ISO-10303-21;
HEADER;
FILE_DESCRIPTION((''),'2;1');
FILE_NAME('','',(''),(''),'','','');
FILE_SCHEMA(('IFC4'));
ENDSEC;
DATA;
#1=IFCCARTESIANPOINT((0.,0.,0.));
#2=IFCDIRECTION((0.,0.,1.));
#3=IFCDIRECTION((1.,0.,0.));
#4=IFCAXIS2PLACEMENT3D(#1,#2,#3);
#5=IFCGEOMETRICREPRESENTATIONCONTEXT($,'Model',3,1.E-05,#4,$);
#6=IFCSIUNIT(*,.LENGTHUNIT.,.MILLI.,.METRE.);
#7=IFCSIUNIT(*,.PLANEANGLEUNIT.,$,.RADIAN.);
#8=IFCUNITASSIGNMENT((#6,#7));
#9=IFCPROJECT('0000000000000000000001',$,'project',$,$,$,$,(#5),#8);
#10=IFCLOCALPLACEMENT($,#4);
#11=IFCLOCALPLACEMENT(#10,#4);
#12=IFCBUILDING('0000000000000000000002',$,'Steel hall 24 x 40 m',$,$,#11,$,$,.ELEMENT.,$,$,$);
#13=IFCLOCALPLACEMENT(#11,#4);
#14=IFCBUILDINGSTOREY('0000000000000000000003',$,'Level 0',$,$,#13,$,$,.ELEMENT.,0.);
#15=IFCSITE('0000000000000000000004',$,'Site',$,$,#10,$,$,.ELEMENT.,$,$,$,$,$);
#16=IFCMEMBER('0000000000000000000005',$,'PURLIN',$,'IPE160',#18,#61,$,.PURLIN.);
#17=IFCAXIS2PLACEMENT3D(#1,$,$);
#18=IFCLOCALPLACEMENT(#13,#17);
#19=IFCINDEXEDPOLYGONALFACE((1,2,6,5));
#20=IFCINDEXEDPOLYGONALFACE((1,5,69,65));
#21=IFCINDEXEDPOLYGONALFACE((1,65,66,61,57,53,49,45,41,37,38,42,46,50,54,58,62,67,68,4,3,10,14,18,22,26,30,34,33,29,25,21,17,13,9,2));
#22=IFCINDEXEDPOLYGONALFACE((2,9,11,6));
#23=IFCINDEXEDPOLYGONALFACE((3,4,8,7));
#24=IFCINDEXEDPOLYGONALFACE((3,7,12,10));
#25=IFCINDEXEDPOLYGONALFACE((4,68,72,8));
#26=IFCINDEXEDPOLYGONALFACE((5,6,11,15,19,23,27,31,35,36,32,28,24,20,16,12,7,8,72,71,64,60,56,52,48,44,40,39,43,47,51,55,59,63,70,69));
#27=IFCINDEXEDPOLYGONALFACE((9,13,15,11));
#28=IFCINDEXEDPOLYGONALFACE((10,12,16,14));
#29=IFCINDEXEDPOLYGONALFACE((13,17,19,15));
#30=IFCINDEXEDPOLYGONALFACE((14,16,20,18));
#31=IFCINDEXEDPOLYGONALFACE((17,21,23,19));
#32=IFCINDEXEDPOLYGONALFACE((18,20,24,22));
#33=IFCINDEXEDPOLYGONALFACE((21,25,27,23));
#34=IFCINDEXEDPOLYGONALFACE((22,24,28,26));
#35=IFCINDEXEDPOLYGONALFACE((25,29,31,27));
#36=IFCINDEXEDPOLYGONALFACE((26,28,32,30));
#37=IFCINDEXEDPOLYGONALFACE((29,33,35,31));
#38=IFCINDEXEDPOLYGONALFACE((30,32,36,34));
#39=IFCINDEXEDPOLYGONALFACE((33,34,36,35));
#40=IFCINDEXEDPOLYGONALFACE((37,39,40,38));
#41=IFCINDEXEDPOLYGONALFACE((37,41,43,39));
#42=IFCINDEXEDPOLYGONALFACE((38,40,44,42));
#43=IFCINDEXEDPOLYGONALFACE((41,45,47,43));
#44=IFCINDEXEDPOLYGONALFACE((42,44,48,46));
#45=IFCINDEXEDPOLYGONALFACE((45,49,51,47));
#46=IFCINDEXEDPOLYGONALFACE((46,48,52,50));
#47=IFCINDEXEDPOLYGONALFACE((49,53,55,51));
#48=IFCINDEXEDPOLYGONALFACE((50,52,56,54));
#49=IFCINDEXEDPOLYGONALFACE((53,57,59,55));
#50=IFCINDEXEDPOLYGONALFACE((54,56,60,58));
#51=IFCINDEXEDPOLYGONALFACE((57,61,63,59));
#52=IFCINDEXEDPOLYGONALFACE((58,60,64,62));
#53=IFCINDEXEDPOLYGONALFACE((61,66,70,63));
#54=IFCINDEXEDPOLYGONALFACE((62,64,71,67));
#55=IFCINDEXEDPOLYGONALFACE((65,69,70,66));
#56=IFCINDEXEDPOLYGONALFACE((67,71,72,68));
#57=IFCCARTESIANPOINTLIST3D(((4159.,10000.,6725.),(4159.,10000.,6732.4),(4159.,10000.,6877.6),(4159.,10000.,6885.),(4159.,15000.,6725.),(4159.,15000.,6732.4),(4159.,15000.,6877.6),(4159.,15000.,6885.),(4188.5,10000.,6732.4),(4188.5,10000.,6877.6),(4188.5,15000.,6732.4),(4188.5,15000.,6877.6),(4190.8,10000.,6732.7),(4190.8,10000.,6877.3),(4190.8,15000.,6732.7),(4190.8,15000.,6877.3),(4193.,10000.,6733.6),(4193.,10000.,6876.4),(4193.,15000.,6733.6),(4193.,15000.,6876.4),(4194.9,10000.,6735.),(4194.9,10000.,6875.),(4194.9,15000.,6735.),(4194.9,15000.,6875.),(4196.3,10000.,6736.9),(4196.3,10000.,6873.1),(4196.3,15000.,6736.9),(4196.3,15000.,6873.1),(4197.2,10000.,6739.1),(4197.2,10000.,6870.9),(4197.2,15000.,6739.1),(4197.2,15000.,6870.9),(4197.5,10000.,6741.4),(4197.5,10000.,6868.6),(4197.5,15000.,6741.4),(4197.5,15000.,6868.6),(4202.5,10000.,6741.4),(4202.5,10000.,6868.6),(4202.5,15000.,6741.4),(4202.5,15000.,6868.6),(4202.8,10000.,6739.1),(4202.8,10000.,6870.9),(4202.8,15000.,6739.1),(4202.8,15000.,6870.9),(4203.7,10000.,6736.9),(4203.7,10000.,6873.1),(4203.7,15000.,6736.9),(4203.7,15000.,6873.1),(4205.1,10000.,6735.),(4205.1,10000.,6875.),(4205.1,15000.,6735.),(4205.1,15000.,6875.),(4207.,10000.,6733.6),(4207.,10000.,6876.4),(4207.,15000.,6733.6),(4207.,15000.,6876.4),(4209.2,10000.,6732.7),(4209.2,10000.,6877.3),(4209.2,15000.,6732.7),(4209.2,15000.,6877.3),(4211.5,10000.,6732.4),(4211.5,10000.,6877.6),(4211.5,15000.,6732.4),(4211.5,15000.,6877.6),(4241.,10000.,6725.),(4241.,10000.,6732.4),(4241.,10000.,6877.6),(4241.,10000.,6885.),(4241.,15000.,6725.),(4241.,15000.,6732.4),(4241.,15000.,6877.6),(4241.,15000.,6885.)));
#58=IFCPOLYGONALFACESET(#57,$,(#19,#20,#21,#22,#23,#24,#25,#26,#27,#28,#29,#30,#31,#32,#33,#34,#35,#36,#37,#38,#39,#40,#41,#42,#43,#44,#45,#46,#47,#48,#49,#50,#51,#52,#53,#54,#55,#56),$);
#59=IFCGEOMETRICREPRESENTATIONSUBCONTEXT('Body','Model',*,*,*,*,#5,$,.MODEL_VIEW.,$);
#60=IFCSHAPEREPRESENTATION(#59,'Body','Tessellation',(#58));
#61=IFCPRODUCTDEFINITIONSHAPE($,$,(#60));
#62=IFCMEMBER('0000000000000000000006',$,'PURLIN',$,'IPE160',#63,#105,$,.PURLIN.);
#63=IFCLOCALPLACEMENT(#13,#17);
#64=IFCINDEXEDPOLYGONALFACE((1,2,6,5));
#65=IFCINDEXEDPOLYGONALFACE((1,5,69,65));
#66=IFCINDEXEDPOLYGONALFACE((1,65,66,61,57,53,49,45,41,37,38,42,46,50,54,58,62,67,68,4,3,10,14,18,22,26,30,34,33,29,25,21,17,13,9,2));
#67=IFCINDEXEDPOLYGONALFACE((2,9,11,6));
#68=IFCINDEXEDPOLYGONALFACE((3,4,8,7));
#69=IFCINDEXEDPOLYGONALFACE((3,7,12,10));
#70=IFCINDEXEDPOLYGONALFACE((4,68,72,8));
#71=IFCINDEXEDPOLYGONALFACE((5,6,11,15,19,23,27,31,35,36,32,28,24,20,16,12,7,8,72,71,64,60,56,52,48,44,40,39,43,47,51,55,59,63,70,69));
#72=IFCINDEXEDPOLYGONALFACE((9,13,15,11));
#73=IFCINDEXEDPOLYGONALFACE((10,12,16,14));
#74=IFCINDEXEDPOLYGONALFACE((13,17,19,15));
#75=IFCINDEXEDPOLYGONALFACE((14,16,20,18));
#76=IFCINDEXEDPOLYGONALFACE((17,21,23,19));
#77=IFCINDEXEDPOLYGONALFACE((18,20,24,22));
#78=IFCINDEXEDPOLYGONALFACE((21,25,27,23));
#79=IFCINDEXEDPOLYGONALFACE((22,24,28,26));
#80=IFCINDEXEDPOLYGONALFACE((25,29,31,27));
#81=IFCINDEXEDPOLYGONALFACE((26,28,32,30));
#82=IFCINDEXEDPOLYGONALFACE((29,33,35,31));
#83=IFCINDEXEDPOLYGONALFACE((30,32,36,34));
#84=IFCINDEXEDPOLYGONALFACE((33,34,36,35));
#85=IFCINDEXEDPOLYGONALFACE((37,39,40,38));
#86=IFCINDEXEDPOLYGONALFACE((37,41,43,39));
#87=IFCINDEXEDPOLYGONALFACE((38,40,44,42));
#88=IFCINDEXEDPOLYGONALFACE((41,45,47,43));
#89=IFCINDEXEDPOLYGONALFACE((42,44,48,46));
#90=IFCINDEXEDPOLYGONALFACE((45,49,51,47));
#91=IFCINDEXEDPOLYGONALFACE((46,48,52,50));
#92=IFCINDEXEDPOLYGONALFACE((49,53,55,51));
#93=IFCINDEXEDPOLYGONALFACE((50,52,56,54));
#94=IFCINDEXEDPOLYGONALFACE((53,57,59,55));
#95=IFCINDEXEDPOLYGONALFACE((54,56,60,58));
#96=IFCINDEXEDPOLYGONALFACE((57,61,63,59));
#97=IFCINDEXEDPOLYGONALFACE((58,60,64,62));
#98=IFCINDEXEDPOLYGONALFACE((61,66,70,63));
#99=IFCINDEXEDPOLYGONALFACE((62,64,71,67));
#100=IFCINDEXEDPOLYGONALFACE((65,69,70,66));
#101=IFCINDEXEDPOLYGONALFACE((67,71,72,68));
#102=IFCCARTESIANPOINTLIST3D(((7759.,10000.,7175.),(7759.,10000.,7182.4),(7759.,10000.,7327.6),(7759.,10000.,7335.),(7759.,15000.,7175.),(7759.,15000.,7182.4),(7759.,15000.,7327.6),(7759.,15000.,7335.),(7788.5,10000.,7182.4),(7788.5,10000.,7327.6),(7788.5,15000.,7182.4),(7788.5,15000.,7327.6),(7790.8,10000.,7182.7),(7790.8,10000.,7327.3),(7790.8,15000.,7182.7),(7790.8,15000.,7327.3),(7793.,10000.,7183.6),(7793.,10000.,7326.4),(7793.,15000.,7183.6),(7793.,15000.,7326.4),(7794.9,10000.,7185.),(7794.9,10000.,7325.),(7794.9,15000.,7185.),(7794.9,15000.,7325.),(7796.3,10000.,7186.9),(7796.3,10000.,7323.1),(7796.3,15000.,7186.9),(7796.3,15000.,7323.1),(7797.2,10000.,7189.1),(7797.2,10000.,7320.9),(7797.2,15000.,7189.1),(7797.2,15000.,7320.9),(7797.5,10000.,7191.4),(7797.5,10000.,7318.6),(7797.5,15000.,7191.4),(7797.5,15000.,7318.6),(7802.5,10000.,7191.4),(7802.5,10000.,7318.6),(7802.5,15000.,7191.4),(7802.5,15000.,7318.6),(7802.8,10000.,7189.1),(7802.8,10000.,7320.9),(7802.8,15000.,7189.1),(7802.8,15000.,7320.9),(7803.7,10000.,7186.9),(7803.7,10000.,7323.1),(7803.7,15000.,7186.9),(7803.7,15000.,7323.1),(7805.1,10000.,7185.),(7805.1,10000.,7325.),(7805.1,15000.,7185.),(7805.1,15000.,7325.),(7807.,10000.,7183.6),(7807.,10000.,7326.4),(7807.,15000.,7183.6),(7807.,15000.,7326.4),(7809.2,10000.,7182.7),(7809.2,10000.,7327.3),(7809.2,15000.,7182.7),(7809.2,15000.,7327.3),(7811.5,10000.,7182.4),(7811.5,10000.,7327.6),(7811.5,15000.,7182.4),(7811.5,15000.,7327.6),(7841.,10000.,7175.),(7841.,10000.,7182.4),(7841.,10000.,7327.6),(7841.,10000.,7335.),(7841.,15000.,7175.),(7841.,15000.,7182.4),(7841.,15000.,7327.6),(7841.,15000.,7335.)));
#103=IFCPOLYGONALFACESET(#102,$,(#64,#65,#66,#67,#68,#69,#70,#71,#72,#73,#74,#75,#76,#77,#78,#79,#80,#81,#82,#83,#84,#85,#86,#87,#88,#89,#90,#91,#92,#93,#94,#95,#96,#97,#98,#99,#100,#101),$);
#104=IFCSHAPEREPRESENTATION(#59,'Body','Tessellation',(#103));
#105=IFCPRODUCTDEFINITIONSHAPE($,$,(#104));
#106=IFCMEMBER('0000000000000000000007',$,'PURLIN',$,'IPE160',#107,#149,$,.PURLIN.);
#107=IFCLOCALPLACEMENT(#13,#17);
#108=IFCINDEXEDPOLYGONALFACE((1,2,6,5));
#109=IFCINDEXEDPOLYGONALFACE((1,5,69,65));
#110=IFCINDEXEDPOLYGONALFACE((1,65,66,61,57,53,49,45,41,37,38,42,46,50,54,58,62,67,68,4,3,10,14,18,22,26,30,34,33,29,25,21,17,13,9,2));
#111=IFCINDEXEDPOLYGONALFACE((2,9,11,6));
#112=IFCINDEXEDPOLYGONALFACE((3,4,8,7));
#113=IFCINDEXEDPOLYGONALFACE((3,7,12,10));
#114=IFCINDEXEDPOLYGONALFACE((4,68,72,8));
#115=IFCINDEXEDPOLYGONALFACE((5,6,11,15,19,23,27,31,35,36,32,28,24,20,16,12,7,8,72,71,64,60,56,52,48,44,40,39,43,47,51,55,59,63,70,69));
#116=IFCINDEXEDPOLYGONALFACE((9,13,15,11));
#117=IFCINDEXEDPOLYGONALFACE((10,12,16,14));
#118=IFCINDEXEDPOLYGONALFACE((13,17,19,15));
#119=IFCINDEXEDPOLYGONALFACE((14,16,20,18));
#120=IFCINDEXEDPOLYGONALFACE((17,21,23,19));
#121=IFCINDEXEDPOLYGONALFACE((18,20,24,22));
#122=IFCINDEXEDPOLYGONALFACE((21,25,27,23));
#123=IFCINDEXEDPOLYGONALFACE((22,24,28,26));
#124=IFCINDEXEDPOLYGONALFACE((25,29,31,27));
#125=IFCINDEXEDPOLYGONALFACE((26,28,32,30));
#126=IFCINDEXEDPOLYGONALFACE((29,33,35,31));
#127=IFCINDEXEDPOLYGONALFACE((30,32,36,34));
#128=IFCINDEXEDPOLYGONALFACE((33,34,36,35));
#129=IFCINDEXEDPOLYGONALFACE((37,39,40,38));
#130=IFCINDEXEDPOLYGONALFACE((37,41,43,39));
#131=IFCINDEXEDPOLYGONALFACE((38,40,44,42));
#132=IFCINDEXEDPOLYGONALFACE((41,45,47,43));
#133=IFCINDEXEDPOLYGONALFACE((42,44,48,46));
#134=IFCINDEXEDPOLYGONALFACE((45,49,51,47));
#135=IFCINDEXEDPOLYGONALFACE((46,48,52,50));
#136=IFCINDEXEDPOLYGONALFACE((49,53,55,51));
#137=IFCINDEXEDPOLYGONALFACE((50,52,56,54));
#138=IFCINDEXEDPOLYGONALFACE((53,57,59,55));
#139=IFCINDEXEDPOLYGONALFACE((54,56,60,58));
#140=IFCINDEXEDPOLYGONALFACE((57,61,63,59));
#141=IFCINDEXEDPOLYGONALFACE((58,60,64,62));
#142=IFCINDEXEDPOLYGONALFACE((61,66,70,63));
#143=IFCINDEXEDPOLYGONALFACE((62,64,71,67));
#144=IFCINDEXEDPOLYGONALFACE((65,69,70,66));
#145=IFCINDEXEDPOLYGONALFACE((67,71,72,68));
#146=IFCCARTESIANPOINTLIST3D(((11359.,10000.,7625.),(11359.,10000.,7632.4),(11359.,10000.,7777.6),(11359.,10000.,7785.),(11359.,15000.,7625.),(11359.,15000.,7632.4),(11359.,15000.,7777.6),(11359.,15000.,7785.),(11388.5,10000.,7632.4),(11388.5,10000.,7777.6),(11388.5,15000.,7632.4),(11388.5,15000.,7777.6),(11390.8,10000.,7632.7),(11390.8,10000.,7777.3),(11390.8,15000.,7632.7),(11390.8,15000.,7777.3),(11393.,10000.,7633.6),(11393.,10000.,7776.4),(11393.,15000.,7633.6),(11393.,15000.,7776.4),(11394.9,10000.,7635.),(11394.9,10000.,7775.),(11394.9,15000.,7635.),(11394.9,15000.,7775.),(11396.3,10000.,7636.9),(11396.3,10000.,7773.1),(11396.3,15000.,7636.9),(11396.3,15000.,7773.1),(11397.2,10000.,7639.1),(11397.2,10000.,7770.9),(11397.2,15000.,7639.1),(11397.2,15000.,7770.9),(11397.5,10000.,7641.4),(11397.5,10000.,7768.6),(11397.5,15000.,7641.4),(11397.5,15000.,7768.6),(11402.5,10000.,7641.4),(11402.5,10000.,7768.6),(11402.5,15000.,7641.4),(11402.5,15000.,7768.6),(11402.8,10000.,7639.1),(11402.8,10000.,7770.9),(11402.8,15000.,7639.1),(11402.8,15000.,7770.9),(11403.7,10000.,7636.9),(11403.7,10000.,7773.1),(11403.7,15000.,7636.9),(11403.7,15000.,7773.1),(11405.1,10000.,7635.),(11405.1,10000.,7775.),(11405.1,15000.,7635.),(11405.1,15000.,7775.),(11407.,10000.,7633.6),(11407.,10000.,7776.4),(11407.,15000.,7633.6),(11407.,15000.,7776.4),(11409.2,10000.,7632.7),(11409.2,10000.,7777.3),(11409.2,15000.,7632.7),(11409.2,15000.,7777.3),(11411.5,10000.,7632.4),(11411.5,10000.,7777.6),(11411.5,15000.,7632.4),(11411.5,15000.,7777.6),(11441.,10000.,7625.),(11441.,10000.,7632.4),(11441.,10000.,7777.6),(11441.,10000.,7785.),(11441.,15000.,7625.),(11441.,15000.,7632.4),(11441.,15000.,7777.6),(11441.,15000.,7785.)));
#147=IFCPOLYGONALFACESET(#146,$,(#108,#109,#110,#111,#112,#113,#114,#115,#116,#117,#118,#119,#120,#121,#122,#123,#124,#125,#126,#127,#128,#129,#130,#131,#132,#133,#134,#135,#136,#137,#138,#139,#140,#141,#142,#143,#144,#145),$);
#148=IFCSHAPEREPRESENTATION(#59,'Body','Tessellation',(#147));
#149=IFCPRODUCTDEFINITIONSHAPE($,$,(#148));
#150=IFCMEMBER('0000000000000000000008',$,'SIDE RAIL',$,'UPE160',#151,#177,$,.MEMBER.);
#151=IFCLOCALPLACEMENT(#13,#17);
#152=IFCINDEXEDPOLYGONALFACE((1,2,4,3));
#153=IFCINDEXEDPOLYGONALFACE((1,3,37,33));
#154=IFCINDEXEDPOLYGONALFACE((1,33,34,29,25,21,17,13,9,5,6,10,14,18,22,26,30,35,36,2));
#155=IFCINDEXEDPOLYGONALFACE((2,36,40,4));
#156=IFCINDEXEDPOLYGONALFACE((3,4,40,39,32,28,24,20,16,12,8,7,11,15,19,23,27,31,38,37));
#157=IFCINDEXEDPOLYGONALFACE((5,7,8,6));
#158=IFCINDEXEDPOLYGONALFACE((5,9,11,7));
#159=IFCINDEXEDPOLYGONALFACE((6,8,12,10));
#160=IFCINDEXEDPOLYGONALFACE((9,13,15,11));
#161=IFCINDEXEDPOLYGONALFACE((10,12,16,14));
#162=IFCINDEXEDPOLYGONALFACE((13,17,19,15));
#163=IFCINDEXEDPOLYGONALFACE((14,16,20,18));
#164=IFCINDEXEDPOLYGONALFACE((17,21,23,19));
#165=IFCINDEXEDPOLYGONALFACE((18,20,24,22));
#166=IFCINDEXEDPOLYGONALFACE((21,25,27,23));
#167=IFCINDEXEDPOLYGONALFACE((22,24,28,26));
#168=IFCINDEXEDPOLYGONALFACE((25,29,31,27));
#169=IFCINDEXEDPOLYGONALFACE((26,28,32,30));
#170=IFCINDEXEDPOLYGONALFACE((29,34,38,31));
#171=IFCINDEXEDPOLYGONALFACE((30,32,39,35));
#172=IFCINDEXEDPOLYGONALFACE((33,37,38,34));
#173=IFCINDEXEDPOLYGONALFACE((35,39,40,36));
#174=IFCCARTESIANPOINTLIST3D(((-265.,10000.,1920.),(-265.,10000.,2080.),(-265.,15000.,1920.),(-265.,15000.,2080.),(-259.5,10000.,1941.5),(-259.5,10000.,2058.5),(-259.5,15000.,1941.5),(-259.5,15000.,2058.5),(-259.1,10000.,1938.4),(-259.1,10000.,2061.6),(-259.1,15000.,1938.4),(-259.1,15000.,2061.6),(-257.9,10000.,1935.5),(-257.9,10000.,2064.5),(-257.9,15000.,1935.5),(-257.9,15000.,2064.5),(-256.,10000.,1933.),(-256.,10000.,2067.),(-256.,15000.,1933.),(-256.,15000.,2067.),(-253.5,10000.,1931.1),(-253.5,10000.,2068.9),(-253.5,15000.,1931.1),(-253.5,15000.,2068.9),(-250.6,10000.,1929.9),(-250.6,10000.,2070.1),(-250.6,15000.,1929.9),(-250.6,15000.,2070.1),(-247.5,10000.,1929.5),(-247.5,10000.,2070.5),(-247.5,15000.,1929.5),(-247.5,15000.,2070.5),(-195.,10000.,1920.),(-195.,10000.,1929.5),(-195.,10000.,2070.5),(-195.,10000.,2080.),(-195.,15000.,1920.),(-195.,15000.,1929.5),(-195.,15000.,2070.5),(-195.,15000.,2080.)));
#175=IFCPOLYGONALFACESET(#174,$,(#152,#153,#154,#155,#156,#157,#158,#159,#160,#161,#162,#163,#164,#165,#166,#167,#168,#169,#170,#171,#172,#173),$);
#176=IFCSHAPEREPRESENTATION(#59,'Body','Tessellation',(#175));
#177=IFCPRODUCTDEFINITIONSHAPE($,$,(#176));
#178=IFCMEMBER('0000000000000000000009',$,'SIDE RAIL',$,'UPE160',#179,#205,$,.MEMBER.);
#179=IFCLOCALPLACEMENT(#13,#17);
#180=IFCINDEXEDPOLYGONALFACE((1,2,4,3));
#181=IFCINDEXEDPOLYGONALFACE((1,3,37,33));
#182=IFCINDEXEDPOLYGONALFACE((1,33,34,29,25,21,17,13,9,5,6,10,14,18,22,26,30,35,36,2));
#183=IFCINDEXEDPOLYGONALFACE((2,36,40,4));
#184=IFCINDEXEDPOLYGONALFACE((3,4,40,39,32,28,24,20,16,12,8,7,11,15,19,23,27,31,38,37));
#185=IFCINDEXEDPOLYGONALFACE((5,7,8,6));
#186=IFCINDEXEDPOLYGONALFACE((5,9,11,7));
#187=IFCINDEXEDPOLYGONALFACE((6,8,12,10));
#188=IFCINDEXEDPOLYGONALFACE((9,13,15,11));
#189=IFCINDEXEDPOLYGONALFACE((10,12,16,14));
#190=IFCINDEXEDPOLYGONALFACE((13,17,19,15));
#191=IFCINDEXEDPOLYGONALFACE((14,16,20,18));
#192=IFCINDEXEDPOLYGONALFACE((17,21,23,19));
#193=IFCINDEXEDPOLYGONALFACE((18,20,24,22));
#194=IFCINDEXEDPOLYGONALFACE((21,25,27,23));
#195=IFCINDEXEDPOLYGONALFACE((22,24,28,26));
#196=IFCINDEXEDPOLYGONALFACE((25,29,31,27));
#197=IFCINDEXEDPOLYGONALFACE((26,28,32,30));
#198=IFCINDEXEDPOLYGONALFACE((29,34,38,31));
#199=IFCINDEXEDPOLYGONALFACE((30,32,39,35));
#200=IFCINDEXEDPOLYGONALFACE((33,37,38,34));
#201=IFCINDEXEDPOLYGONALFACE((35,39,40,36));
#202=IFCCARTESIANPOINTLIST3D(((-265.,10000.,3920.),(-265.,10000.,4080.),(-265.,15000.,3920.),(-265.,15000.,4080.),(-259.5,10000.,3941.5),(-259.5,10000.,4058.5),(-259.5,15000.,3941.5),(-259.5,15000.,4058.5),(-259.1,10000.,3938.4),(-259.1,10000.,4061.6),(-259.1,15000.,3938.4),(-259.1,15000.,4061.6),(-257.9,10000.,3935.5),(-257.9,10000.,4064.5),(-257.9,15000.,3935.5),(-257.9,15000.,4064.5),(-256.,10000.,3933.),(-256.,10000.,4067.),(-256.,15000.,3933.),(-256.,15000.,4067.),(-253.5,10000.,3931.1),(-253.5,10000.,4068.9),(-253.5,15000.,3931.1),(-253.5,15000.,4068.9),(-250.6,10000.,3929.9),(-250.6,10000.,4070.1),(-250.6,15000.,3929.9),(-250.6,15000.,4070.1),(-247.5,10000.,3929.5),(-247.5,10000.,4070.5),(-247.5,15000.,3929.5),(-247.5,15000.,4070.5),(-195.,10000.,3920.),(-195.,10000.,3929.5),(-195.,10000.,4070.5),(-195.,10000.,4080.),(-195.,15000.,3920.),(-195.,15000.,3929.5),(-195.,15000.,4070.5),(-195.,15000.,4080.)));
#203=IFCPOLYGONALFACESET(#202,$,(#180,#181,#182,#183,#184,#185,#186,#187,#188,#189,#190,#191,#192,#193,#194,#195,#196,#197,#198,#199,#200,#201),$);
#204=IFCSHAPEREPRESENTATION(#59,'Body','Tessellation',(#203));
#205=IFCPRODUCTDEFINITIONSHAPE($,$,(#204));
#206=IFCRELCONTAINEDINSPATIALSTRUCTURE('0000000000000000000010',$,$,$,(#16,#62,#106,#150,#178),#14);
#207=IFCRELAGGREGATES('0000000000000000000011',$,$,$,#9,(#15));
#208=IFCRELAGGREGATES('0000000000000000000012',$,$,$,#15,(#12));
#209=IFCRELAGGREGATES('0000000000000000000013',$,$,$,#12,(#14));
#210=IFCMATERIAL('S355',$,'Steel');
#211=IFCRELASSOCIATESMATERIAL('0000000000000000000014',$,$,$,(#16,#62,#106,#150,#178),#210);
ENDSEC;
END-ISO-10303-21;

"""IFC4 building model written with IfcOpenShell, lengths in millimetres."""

from ifc_helpers import new_model, si_unit, frame, origin_with_axes, place, context, subcontext, project, spatial, i_section, u_section, extrude, material, element, save


model = new_model("IFC4")

# Units and contexts
model_context = context("Model", 3, precision=1e-05, world=origin_with_axes())
body_context = subcontext(model_context, "Body", "Model", "MODEL_VIEW")
ifc_project = project(units=[si_unit("LENGTHUNIT", "METRE", prefix="MILLI"), si_unit("PLANEANGLEUNIT", "RADIAN")], contexts=[model_context])

# Site, building, storey
site_placement = place(None, origin_with_axes())
site = spatial("IfcSite", under=ifc_project, at=site_placement, Name="Site", CompositionType="ELEMENT")
building_placement = place(site_placement, origin_with_axes())
building = spatial("IfcBuilding", under=site, at=building_placement, Name="Steel hall 24 x 40 m", CompositionType="ELEMENT")
storey_placement = place(building_placement, origin_with_axes())
storey = spatial("IfcBuildingStorey", under=building, at=storey_placement, Name="Level 0", CompositionType="ELEMENT", Elevation=0.0)

# Shared definitions
ifc_material = material(Name="S355", Category="Steel")

# Members
for number, where, z_axis, x_axis, name in (
    (1, (4200.0, 10000.0, 6805.0), (0.0, 1.0, 0.0), (1.0, 0.0, 0.0), "PURLIN"),
    (2, (7800.0, 10000.0, 7255.0), (0.0, 1.0, 0.0), (1.0, 0.0, 0.0), "PURLIN"),
    (3, (11400.0, 10000.0, 7705.0), (0.0, 1.0, 0.0), (1.0, 0.0, 0.0), "PURLIN"),
):
    element("IfcMember", number, at=place(storey_placement, frame(where, z_axis=z_axis, x_axis=x_axis)), inside=storey, material=ifc_material, Name=name, ObjectType="IPE160", PredefinedType="PURLIN", context=body_context, shape_type="SweptSolid", body=[
        extrude(i_section(OverallWidth=82.0, OverallDepth=160.0, WebThickness=5.0, FlangeThickness=7.4, FilletRadius=9.0), origin_with_axes(), (0.0, 0.0, 1.0), 5000.0),
    ])
for number, where, z_axis, x_axis, name in (
    (4, (-230.0, 10000.0, 2000.0), (0.0, 1.0, 0.0), (1.0, 0.0, 0.0), "SIDE RAIL"),
    (5, (-230.0, 10000.0, 4000.0), (0.0, 1.0, 0.0), (1.0, 0.0, 0.0), "SIDE RAIL"),
):
    element("IfcMember", number, at=place(storey_placement, frame(where, z_axis=z_axis, x_axis=x_axis)), inside=storey, material=ifc_material, Name=name, ObjectType="UPE160", PredefinedType="MEMBER", context=body_context, shape_type="SweptSolid", body=[
        extrude(u_section(Depth=160.0, FlangeWidth=70.0, WebThickness=5.5, FlangeThickness=9.5, FilletRadius=12.0), origin_with_axes(), (0.0, 0.0, 1.0), 5000.0),
    ])

save(model, "model.ifc")
